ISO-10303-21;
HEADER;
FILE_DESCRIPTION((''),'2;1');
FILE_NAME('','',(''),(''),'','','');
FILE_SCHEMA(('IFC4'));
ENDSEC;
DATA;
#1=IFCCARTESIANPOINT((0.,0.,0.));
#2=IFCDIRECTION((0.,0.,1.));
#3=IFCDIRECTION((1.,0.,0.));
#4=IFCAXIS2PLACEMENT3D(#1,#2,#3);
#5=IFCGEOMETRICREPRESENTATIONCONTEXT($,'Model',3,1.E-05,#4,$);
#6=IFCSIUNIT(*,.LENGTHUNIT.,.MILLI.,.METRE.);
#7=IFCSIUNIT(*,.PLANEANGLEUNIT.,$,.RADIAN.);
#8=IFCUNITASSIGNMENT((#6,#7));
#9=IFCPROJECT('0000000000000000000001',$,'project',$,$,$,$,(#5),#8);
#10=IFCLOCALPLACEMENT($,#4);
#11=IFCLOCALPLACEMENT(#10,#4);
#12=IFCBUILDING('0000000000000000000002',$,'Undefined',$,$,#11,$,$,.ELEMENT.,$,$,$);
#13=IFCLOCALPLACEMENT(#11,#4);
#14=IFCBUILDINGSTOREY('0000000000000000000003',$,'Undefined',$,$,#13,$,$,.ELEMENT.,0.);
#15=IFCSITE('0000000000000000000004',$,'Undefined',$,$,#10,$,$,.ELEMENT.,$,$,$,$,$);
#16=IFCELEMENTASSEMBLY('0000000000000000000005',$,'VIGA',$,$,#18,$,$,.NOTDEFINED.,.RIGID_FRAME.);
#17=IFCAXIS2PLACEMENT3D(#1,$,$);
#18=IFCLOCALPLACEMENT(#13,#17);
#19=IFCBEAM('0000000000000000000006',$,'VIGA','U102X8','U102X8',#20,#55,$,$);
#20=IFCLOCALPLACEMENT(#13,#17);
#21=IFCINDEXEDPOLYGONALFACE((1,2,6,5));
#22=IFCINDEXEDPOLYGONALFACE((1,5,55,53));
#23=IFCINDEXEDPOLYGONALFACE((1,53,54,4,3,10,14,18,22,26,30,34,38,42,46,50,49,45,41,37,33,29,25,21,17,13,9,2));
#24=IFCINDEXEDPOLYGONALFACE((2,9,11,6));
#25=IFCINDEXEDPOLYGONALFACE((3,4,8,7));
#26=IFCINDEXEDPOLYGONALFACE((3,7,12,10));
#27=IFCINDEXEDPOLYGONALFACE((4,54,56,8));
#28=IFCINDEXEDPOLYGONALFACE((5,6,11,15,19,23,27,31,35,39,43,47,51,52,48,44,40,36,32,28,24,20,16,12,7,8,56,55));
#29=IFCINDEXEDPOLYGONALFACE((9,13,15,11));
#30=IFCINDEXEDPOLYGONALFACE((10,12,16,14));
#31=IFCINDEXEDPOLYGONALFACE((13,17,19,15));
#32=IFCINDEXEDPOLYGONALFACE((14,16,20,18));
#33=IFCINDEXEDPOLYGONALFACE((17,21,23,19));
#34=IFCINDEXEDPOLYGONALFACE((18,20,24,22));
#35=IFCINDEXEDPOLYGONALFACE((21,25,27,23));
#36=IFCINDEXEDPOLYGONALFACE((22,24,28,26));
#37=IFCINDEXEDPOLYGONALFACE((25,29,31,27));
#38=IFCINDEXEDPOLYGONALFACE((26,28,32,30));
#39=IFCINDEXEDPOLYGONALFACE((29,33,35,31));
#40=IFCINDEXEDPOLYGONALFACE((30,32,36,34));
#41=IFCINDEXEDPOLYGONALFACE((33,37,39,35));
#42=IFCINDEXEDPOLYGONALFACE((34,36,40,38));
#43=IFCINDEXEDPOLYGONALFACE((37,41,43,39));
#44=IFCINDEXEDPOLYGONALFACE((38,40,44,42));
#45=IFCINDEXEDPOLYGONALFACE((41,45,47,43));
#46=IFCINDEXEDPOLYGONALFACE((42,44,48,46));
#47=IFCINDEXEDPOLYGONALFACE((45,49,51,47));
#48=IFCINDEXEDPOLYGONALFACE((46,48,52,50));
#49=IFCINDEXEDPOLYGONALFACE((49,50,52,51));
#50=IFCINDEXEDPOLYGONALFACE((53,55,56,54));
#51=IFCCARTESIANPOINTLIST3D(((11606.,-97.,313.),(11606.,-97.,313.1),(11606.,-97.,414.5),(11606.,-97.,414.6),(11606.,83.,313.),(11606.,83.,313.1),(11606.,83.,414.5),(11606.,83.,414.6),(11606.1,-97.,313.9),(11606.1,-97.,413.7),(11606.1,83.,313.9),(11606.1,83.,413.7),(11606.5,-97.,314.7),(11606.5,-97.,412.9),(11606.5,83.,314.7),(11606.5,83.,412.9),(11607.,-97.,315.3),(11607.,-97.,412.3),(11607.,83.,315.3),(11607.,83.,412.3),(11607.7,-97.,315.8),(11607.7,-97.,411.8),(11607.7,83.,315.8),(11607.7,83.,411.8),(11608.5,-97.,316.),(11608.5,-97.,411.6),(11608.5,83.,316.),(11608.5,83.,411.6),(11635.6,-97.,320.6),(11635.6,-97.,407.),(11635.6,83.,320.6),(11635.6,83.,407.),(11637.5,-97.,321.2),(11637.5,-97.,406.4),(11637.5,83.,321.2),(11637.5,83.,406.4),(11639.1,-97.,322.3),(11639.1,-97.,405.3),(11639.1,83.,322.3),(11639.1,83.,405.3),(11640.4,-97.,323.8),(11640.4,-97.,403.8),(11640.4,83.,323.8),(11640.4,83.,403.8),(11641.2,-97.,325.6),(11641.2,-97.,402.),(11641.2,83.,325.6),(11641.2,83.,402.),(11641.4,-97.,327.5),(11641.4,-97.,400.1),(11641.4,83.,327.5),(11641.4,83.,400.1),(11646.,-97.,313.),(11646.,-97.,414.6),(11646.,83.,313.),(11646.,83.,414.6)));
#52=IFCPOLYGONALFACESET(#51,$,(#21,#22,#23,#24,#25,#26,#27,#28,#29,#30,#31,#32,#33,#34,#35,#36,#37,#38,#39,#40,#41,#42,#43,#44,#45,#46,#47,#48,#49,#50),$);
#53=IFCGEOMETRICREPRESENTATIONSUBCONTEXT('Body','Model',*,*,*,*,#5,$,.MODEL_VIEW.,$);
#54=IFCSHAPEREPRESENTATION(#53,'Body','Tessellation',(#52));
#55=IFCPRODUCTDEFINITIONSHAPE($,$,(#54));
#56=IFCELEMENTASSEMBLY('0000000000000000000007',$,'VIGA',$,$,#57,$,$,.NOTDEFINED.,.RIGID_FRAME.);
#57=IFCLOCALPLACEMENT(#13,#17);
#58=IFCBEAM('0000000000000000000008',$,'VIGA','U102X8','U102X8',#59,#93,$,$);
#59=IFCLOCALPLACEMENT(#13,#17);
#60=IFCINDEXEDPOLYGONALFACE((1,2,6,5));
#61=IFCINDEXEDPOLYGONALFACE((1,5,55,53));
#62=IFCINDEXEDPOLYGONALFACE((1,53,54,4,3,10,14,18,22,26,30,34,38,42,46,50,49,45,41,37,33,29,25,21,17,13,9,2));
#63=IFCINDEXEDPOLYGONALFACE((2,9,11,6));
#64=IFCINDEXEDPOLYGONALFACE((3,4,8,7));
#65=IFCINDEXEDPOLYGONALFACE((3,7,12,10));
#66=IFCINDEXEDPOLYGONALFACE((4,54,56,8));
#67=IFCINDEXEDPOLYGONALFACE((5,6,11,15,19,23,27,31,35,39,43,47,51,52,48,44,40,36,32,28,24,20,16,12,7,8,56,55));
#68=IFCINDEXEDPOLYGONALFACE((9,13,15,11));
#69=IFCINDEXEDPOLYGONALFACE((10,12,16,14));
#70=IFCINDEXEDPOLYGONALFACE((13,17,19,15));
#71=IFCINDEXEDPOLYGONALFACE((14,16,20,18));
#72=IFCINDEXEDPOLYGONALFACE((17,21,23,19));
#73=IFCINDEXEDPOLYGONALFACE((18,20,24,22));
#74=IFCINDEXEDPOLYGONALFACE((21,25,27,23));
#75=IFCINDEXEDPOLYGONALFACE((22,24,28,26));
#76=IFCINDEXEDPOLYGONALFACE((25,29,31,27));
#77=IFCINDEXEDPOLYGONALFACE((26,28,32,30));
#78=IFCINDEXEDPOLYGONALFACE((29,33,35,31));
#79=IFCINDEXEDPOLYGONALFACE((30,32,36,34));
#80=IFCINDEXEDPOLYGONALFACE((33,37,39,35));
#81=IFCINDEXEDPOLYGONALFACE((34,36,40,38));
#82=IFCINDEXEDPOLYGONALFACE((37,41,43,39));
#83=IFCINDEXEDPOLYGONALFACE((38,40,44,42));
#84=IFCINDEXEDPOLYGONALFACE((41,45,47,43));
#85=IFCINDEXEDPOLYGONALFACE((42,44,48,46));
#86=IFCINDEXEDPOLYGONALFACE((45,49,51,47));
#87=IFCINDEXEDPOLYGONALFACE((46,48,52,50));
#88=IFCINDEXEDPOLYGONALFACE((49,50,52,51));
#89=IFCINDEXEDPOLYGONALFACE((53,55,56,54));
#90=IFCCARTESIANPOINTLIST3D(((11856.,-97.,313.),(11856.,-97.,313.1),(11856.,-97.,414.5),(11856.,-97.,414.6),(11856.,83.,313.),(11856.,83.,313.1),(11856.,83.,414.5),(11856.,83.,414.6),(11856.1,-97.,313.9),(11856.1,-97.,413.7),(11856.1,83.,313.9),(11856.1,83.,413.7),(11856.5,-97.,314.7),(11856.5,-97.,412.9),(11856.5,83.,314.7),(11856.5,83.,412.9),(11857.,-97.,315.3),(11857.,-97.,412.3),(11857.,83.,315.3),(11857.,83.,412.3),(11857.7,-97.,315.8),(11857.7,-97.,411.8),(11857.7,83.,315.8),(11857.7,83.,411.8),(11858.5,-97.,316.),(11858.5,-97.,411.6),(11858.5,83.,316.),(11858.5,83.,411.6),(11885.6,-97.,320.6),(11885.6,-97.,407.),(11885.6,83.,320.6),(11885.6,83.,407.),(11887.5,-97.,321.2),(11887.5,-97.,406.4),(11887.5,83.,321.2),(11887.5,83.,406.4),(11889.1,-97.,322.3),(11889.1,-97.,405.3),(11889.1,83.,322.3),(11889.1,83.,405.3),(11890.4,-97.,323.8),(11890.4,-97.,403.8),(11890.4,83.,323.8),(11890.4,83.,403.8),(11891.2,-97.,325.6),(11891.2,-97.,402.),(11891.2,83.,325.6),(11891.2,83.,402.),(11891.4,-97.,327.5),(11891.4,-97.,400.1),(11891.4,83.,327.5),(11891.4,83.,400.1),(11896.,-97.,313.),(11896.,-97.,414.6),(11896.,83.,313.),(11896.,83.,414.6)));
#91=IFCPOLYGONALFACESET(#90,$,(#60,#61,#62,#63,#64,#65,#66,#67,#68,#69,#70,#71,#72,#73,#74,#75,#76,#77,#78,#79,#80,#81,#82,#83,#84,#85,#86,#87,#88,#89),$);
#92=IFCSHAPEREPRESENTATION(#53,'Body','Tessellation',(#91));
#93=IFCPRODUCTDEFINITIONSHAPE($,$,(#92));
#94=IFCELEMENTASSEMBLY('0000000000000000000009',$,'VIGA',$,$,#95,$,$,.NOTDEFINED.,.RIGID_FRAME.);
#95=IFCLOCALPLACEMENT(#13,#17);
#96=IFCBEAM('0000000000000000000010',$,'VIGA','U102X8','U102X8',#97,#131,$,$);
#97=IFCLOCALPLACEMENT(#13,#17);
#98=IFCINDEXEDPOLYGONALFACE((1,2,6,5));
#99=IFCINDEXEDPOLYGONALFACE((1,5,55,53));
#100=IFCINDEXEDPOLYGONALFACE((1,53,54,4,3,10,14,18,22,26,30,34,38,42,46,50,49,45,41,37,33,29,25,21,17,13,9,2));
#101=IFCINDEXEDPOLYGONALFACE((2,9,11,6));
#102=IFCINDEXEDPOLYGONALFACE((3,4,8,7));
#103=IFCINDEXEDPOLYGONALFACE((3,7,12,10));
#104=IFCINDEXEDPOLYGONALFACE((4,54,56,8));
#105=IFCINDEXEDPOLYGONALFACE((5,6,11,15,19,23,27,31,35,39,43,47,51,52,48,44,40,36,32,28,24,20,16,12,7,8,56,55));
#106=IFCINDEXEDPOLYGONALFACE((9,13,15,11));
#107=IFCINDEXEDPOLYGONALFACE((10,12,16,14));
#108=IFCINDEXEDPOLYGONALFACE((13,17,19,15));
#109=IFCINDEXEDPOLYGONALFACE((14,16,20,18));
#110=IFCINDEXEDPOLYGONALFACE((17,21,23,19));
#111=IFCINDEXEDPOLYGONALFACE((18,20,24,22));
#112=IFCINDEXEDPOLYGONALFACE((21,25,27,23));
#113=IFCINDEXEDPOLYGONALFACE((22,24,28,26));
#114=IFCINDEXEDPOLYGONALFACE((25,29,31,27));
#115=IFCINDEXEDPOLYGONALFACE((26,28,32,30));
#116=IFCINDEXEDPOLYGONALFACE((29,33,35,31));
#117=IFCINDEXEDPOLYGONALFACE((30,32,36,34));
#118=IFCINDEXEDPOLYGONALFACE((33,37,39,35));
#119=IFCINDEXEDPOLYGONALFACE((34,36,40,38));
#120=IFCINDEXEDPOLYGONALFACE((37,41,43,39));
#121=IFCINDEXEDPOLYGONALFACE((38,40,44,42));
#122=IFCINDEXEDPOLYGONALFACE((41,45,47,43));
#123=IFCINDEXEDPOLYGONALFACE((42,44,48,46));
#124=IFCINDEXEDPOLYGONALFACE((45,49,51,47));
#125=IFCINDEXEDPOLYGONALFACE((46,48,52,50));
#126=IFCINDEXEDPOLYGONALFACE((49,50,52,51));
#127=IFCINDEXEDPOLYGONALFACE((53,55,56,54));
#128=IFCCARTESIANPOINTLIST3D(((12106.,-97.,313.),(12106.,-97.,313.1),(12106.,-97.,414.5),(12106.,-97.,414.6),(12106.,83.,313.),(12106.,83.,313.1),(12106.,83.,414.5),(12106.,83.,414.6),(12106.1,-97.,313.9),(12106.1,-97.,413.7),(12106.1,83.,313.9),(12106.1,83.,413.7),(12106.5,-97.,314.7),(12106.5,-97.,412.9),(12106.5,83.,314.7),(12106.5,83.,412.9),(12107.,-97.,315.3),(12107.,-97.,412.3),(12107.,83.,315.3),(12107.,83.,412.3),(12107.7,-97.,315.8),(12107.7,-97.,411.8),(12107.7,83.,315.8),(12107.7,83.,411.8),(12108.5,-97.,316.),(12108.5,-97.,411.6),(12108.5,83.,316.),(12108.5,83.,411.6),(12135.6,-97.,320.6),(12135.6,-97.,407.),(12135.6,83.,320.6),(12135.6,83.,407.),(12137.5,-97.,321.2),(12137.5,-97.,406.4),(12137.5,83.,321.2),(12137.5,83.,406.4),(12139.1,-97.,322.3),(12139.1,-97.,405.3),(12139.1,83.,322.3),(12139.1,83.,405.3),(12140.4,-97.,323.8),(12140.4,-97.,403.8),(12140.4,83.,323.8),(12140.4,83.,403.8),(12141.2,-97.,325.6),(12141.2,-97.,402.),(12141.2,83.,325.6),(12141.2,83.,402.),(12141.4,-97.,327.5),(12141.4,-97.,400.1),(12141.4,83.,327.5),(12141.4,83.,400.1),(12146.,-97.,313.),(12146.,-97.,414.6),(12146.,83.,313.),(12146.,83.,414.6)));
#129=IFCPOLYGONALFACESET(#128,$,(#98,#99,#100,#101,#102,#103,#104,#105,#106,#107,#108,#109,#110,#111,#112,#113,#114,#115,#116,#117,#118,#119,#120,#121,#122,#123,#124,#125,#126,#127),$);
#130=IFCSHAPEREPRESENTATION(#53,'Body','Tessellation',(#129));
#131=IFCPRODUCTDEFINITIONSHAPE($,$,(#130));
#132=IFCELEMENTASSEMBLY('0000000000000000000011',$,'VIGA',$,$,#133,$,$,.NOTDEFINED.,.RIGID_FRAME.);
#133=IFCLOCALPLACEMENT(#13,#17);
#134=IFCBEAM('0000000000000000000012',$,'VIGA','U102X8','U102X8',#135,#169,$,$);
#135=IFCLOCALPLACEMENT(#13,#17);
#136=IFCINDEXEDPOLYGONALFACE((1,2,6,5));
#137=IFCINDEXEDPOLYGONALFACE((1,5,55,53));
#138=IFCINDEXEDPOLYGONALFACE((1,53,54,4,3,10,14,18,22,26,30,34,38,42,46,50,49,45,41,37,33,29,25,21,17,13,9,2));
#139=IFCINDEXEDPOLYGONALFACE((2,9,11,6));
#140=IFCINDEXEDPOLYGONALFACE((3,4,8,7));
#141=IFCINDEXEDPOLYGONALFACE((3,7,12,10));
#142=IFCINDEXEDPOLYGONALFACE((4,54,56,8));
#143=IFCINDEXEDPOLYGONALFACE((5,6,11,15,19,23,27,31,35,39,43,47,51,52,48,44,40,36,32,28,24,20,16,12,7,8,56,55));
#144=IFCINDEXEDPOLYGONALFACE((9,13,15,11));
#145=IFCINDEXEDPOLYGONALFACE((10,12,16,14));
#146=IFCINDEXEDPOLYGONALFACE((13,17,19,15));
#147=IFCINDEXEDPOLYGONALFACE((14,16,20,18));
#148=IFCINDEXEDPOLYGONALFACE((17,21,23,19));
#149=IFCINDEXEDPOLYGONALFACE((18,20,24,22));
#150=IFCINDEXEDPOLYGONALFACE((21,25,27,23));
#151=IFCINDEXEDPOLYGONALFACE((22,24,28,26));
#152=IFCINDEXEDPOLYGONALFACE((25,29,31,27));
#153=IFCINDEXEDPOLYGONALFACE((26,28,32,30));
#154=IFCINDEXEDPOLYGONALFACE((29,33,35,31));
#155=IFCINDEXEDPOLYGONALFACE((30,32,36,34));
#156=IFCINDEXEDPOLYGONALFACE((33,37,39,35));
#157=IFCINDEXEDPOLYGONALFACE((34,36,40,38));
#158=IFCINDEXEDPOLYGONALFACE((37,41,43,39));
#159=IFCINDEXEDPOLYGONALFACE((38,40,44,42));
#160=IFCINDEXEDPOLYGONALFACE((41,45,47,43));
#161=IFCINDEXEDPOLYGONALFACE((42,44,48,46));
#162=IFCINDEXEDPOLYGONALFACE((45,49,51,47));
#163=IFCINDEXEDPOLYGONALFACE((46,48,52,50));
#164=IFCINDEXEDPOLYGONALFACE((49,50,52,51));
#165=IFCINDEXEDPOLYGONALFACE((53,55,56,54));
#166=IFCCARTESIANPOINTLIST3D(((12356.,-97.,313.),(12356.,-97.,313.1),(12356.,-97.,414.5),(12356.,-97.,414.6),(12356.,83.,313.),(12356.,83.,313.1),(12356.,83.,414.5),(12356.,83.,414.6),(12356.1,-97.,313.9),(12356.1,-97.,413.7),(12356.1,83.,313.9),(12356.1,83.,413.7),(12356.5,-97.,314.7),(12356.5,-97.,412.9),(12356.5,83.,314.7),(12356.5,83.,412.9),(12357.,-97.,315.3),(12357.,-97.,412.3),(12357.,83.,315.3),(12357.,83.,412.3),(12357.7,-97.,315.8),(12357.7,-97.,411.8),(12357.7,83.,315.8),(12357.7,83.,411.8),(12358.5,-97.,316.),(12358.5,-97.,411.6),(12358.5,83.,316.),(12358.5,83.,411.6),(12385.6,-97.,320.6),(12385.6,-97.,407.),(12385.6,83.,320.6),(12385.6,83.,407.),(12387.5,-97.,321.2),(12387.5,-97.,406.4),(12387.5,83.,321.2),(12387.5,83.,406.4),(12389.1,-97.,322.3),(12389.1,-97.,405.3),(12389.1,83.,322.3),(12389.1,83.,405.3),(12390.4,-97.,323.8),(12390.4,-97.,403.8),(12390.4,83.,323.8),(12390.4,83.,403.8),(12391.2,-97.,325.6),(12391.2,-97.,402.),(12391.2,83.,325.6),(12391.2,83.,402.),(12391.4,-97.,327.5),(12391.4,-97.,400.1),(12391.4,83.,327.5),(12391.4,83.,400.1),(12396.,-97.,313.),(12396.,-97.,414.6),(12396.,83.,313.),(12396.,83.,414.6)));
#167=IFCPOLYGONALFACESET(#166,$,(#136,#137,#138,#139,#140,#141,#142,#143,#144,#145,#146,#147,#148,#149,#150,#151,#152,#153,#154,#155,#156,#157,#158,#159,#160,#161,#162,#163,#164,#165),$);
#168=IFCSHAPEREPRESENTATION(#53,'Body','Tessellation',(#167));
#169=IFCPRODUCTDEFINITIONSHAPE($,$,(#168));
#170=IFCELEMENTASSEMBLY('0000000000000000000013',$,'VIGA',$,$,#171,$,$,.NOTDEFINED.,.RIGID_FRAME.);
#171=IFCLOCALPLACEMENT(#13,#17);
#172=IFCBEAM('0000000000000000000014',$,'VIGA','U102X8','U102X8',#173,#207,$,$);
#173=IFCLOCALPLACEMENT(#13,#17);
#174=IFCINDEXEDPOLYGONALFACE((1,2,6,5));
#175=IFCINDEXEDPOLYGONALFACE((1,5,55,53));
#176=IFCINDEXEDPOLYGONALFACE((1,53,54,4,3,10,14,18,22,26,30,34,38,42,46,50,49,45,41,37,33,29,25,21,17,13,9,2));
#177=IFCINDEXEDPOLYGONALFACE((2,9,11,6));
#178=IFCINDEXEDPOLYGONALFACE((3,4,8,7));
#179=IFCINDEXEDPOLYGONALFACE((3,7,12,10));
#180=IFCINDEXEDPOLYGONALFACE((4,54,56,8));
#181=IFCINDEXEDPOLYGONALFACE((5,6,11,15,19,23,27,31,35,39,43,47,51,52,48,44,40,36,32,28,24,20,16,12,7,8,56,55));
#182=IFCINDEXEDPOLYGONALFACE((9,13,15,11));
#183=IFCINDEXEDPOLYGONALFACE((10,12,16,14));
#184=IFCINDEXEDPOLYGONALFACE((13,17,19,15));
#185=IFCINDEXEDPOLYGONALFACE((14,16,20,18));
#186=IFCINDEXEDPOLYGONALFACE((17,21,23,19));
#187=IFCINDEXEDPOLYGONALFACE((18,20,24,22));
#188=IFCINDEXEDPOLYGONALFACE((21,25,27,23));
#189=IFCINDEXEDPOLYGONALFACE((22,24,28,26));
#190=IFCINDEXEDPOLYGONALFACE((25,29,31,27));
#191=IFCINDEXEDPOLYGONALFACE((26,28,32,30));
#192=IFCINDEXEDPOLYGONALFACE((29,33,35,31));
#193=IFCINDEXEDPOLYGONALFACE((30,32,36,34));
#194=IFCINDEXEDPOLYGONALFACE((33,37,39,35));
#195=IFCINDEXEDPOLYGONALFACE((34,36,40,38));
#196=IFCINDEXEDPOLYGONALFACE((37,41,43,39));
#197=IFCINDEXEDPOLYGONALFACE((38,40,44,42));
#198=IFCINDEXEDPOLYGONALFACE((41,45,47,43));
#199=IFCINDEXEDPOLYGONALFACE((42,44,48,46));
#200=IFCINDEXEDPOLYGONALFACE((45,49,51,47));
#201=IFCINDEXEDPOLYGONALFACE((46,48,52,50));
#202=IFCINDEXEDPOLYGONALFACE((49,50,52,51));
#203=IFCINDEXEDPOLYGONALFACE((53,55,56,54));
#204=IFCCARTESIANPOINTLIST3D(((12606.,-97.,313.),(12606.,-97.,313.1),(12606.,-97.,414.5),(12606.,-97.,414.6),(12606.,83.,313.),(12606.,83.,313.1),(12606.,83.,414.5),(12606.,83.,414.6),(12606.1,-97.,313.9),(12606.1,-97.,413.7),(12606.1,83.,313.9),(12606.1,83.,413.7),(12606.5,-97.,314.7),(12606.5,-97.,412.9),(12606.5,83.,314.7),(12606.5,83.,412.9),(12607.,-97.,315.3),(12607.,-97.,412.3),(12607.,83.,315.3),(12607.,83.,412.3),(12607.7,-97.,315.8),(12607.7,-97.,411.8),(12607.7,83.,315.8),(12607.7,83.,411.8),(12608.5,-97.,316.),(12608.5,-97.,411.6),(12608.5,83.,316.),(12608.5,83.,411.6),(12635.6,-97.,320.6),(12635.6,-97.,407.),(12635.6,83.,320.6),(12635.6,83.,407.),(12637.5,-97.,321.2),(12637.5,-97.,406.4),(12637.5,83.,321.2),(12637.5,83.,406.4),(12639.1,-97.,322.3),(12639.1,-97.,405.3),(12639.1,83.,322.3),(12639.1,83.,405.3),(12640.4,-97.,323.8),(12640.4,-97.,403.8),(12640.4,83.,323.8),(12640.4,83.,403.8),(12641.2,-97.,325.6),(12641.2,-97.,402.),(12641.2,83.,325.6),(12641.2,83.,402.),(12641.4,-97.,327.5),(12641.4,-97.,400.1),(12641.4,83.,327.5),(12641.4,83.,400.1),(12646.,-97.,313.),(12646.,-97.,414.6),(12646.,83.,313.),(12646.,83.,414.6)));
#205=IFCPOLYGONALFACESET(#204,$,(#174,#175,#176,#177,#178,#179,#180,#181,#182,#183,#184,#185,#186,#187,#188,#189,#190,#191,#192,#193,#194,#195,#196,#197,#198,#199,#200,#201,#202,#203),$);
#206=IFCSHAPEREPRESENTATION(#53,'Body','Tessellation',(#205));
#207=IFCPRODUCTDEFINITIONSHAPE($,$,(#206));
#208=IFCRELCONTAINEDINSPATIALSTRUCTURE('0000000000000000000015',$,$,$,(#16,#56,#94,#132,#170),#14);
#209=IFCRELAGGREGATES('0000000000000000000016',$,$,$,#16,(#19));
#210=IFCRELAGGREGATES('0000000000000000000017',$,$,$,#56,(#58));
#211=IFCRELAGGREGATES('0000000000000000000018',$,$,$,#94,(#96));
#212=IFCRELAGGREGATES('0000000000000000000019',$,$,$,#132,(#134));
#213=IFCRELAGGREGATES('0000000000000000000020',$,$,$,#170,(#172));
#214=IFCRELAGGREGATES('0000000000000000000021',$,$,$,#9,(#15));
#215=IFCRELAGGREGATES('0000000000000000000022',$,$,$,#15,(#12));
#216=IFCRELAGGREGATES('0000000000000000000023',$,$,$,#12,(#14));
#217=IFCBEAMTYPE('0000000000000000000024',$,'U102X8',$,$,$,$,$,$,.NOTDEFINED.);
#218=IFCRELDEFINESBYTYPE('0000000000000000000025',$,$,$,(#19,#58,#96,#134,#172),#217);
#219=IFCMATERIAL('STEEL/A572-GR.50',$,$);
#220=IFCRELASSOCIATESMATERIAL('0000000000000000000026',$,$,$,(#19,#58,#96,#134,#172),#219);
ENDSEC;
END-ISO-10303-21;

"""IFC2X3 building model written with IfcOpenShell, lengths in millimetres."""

from ifc_helpers import new_model, si_unit, frame, origin_with_axes, origin_2d_with_axis, place, context, subcontext, project, spatial, u_section, extrude, material, type_object, element, aggregate, save


model = new_model("IFC2X3")

# Units and contexts
model_context = context("Model", 3, precision=1e-05, world=origin_with_axes())
body_context = subcontext(model_context, "Body", "Model", "MODEL_VIEW")
ifc_project = project(units=[si_unit("LENGTHUNIT", "METRE", prefix="MILLI"), si_unit("PLANEANGLEUNIT", "RADIAN")], contexts=[model_context])

# Site, building, storey
site_placement = place(None, origin_with_axes())
site = spatial("IfcSite", under=ifc_project, at=site_placement, Name="Undefined", CompositionType="ELEMENT")
building_placement = place(site_placement, origin_with_axes())
building = spatial("IfcBuilding", under=site, at=building_placement, Name="Undefined", CompositionType="ELEMENT")
storey_placement = place(building_placement, origin_with_axes())
storey = spatial("IfcBuildingStorey", under=building, at=storey_placement, Name="Undefined", CompositionType="ELEMENT", Elevation=0.0)

# Element assemblies, beams
ifc_material_1 = material(Name="STEEL/A572-GR.50")
beam_type_1 = type_object("IfcBeamType", Name="U102X8", PredefinedType="NOTDEFINED")
assembly_1_placement = place(storey_placement, origin_with_axes())
assembly_1 = element("IfcElementAssembly", 1, at=assembly_1_placement, inside=storey, Name="VIGA", AssemblyPlace="NOTDEFINED", PredefinedType="RIGID_FRAME")
beam_1_placement = place(assembly_1_placement, frame((11626.0, 83.0, 363.8), z_axis=(0.0, 0.0, 1.0), x_axis=(0.0, -1.0, 0.0)))
beam_1 = element("IfcBeam", 2, at=beam_1_placement, type_object=beam_type_1, material=ifc_material_1, Name="VIGA", Description="U102X8", ObjectType="U102X8", context=body_context, shape_type="SweptSolid", body=[
    extrude(u_section(Depth=101.6, FlangeWidth=40.0, WebThickness=4.6, FlangeThickness=6.0, FilletRadius=7.0, EdgeRadius=3.0, FlangeSlope=0.16839, at=origin_2d_with_axis()), frame((180.0, 0.0, 0.0), z_axis=(-1.0, 0.0, 0.0), x_axis=(0.0, -1.0, 0.0)), (0.0, 0.0, 1.0), 180.0),
])
aggregate(assembly_1, [beam_1])
assembly_2_placement = place(storey_placement, origin_with_axes())
assembly_2 = element("IfcElementAssembly", 3, at=assembly_2_placement, inside=storey, Name="VIGA", AssemblyPlace="NOTDEFINED", PredefinedType="RIGID_FRAME")
beam_2_placement = place(assembly_2_placement, frame((11876.0, 83.0, 363.8), z_axis=(0.0, 0.0, 1.0), x_axis=(0.0, -1.0, 0.0)))
beam_2 = element("IfcBeam", 4, at=beam_2_placement, type_object=beam_type_1, material=ifc_material_1, Name="VIGA", Description="U102X8", ObjectType="U102X8", context=body_context, shape_type="SweptSolid", body=[
    extrude(u_section(Depth=101.6, FlangeWidth=40.0, WebThickness=4.6, FlangeThickness=6.0, FilletRadius=7.0, EdgeRadius=3.0, FlangeSlope=0.16839, at=origin_2d_with_axis()), frame((180.0, 0.0, 0.0), z_axis=(-1.0, 0.0, 0.0), x_axis=(0.0, -1.0, 0.0)), (0.0, 0.0, 1.0), 180.0),
])
aggregate(assembly_2, [beam_2])
assembly_3_placement = place(storey_placement, origin_with_axes())
assembly_3 = element("IfcElementAssembly", 5, at=assembly_3_placement, inside=storey, Name="VIGA", AssemblyPlace="NOTDEFINED", PredefinedType="RIGID_FRAME")
beam_3_placement = place(assembly_3_placement, frame((12126.0, 83.0, 363.8), z_axis=(0.0, 0.0, 1.0), x_axis=(0.0, -1.0, 0.0)))
beam_3 = element("IfcBeam", 6, at=beam_3_placement, type_object=beam_type_1, material=ifc_material_1, Name="VIGA", Description="U102X8", ObjectType="U102X8", context=body_context, shape_type="SweptSolid", body=[
    extrude(u_section(Depth=101.6, FlangeWidth=40.0, WebThickness=4.6, FlangeThickness=6.0, FilletRadius=7.0, EdgeRadius=3.0, FlangeSlope=0.16839, at=origin_2d_with_axis()), frame((180.0, 0.0, 0.0), z_axis=(-1.0, 0.0, 0.0), x_axis=(0.0, -1.0, 0.0)), (0.0, 0.0, 1.0), 180.0),
])
aggregate(assembly_3, [beam_3])
assembly_4_placement = place(storey_placement, origin_with_axes())
assembly_4 = element("IfcElementAssembly", 7, at=assembly_4_placement, inside=storey, Name="VIGA", AssemblyPlace="NOTDEFINED", PredefinedType="RIGID_FRAME")
beam_4_placement = place(assembly_4_placement, frame((12376.0, 83.0, 363.8), z_axis=(0.0, 0.0, 1.0), x_axis=(0.0, -1.0, 0.0)))
beam_4 = element("IfcBeam", 8, at=beam_4_placement, type_object=beam_type_1, material=ifc_material_1, Name="VIGA", Description="U102X8", ObjectType="U102X8", context=body_context, shape_type="SweptSolid", body=[
    extrude(u_section(Depth=101.6, FlangeWidth=40.0, WebThickness=4.6, FlangeThickness=6.0, FilletRadius=7.0, EdgeRadius=3.0, FlangeSlope=0.16839, at=origin_2d_with_axis()), frame((180.0, 0.0, 0.0), z_axis=(-1.0, 0.0, 0.0), x_axis=(0.0, -1.0, 0.0)), (0.0, 0.0, 1.0), 180.0),
])
aggregate(assembly_4, [beam_4])
assembly_5_placement = place(storey_placement, origin_with_axes())
assembly_5 = element("IfcElementAssembly", 9, at=assembly_5_placement, inside=storey, Name="VIGA", AssemblyPlace="NOTDEFINED", PredefinedType="RIGID_FRAME")
beam_5_placement = place(assembly_5_placement, frame((12626.0, 83.0, 363.8), z_axis=(0.0, 0.0, 1.0), x_axis=(0.0, -1.0, 0.0)))
beam_5 = element("IfcBeam", 10, at=beam_5_placement, type_object=beam_type_1, material=ifc_material_1, Name="VIGA", Description="U102X8", ObjectType="U102X8", context=body_context, shape_type="SweptSolid", body=[
    extrude(u_section(Depth=101.6, FlangeWidth=40.0, WebThickness=4.6, FlangeThickness=6.0, FilletRadius=7.0, EdgeRadius=3.0, FlangeSlope=0.16839, at=origin_2d_with_axis()), frame((180.0, 0.0, 0.0), z_axis=(-1.0, 0.0, 0.0), x_axis=(0.0, -1.0, 0.0)), (0.0, 0.0, 1.0), 180.0),
])
aggregate(assembly_5, [beam_5])

save(model, "model.ifc")
